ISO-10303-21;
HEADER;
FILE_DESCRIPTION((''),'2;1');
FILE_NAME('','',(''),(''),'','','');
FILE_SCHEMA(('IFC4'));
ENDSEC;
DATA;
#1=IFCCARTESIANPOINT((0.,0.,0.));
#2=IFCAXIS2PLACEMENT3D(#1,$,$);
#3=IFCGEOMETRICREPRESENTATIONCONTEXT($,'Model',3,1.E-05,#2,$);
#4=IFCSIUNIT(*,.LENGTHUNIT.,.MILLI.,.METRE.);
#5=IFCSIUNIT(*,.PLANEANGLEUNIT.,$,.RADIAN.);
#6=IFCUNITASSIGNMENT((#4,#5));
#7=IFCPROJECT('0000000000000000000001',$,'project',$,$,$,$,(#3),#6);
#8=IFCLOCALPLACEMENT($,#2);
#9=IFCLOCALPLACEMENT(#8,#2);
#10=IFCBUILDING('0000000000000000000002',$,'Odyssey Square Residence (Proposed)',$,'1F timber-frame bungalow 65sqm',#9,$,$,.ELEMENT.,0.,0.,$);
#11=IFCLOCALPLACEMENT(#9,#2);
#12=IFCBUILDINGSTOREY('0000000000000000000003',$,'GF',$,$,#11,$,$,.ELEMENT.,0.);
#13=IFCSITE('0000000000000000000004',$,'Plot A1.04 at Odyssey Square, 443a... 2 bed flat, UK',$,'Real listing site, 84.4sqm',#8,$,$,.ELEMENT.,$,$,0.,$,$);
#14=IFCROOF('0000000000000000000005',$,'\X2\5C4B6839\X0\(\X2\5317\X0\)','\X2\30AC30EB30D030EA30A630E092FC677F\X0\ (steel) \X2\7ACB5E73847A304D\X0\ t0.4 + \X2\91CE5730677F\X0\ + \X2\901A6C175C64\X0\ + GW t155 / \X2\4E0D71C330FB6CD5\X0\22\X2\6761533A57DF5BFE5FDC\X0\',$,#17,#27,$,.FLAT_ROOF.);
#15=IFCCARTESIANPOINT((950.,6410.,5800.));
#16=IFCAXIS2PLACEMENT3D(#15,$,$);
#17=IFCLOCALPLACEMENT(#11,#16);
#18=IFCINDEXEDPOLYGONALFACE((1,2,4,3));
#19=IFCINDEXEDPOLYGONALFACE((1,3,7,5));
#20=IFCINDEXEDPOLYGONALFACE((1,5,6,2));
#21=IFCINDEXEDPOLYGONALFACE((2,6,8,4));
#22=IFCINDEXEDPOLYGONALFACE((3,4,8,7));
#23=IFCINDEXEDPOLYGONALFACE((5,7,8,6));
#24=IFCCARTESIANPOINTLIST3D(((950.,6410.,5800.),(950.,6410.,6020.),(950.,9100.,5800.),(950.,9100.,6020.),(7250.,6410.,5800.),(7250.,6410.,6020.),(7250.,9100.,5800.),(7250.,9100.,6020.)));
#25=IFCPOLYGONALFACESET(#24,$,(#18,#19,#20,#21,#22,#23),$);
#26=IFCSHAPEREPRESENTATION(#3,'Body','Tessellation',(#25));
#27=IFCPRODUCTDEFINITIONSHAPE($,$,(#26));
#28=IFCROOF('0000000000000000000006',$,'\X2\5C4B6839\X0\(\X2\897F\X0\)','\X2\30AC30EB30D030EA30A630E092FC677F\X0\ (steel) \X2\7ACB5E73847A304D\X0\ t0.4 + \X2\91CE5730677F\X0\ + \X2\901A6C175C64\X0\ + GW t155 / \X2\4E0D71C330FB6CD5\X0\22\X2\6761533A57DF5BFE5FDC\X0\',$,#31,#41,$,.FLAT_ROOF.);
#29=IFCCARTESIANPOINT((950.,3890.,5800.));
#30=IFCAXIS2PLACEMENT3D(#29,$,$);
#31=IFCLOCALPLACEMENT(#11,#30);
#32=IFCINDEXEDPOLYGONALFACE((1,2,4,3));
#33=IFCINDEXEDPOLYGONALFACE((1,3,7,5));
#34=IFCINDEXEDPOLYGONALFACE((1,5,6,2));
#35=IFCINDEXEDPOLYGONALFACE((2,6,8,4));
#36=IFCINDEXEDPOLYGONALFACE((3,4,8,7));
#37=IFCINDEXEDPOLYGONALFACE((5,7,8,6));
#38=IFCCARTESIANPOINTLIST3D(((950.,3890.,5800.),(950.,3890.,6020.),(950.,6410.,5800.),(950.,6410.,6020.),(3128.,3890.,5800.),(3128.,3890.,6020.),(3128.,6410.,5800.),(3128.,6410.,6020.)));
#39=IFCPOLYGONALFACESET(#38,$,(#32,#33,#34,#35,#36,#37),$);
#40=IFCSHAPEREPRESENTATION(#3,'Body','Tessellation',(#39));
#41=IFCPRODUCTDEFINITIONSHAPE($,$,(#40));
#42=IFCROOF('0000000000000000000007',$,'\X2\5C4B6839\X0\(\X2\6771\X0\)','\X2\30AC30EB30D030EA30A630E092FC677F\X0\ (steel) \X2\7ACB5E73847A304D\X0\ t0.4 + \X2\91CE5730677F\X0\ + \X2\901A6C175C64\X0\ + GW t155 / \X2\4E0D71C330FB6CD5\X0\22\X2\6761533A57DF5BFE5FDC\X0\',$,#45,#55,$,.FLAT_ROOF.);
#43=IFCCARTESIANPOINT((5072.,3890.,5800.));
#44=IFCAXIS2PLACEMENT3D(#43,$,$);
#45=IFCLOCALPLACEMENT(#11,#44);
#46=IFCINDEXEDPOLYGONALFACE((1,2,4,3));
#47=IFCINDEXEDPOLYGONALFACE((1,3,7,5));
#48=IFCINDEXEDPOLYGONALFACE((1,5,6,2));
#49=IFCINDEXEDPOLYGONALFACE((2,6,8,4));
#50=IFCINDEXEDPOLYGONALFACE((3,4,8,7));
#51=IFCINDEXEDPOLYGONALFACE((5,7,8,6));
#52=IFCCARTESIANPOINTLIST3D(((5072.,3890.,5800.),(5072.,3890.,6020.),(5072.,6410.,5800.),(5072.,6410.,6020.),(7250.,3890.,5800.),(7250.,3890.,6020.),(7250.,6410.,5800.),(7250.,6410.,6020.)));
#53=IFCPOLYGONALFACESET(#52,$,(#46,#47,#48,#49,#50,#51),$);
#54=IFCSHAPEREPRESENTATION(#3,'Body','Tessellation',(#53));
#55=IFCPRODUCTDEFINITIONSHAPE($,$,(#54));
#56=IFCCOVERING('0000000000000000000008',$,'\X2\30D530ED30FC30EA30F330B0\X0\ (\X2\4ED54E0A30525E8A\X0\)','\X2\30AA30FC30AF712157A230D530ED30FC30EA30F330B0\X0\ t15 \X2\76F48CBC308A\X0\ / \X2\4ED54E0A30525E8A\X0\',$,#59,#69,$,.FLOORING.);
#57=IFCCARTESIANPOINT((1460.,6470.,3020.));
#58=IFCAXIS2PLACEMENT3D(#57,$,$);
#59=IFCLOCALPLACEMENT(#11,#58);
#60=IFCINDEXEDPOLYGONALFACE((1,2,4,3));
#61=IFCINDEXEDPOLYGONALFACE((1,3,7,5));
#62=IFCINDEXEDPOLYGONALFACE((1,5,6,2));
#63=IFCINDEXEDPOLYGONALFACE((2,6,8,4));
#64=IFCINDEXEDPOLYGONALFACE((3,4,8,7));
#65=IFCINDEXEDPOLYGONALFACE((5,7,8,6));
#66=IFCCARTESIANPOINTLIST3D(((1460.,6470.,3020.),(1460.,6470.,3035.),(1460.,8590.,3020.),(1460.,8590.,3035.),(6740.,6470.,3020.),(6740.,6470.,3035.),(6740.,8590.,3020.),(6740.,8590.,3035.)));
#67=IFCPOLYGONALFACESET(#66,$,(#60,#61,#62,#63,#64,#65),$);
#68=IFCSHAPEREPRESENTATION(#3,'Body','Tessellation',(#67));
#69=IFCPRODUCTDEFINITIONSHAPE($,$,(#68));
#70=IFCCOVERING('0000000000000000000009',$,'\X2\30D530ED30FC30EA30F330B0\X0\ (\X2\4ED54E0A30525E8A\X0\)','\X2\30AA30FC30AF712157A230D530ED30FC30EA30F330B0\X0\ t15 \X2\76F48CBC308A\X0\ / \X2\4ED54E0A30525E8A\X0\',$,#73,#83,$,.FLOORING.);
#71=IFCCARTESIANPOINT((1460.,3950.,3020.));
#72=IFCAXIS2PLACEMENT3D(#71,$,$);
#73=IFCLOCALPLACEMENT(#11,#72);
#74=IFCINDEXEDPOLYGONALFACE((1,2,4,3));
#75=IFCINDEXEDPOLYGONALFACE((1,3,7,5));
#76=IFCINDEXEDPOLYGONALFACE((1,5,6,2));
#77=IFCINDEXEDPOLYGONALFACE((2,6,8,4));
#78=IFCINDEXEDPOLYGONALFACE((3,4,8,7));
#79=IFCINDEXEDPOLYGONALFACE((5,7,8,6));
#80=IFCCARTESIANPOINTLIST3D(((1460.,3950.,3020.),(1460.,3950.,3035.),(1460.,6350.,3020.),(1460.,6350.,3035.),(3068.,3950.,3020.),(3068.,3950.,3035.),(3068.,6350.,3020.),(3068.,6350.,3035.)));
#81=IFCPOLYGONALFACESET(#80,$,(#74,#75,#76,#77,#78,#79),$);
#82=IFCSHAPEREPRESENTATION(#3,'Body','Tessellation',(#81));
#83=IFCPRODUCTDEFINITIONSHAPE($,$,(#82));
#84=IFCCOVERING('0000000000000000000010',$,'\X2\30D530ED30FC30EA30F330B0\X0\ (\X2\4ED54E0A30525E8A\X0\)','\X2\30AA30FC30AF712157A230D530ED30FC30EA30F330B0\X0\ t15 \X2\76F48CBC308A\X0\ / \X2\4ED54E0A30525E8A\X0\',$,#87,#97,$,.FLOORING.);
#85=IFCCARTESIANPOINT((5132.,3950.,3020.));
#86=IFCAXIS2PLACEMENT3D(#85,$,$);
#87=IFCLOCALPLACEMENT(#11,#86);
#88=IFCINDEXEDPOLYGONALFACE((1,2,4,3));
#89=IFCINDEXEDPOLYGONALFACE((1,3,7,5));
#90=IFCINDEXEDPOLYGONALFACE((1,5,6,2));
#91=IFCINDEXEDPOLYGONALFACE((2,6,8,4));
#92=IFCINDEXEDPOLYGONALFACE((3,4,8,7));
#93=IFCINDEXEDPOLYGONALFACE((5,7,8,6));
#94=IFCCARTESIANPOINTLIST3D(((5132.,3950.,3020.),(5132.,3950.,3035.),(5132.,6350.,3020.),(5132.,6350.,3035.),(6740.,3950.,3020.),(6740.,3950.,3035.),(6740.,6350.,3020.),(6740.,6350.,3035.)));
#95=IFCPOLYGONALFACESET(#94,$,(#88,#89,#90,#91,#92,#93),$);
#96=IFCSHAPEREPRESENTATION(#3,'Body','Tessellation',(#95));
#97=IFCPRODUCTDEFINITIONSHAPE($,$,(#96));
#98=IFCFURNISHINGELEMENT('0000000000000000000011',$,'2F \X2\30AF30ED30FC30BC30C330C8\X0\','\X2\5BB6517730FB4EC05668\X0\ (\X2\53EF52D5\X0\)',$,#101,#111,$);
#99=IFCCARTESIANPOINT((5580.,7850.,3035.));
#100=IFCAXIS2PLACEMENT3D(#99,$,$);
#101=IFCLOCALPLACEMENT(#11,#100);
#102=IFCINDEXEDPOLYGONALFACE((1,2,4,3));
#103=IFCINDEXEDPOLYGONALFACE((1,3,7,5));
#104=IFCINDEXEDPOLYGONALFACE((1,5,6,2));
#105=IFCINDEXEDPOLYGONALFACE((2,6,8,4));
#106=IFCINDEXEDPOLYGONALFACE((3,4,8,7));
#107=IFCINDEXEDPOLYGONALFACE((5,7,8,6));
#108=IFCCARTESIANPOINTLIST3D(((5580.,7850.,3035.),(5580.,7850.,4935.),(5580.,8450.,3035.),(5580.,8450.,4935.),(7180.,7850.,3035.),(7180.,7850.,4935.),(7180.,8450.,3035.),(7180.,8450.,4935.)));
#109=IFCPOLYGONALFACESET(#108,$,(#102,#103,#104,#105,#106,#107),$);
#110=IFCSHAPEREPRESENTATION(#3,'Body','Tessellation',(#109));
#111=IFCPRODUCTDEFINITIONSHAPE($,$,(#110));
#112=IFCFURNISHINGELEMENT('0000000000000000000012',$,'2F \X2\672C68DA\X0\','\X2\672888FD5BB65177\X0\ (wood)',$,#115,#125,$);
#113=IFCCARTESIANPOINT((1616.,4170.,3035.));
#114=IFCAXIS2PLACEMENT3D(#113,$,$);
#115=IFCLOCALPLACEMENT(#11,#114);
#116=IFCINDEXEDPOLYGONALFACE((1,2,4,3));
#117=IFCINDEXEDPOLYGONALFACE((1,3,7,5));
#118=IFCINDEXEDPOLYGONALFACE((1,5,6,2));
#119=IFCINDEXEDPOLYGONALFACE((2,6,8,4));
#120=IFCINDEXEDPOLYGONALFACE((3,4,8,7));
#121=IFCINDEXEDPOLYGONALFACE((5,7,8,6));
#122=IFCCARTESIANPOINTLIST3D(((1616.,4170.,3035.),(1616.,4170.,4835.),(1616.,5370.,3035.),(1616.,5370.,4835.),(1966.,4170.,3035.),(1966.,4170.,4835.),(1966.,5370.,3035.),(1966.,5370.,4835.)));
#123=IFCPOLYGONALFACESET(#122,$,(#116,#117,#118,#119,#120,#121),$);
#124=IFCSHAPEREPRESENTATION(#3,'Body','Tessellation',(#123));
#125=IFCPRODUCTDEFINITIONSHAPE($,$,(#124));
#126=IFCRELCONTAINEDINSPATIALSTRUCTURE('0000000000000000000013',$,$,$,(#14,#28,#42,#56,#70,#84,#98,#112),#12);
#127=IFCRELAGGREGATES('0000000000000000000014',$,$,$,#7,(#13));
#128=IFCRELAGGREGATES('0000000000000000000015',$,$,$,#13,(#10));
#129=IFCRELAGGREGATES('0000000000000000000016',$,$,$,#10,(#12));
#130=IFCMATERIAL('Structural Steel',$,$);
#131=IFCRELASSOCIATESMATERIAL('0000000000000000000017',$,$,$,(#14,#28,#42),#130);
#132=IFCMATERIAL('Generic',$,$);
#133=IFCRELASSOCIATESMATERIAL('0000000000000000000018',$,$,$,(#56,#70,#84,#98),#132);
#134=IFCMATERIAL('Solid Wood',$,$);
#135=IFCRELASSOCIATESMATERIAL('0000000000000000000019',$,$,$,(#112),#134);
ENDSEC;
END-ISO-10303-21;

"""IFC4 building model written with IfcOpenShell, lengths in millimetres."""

from ifc_helpers import new_model, si_unit, frame, frame_2d, origin, place, context, project, spatial, rectangle, extrude, material, element, save


model = new_model("IFC4")

# Units and contexts
model_context = context("Model", 3, precision=1e-05, world=origin())
ifc_project = project(units=[si_unit("LENGTHUNIT", "METRE", prefix="MILLI"), si_unit("PLANEANGLEUNIT", "RADIAN")], contexts=[model_context])

# Site, building, storey
site_placement = place(None, origin())
site = spatial("IfcSite", under=ifc_project, at=site_placement, Name="Plot A1.04 at Odyssey Square, 443a... 2 bed flat, UK", ObjectType="Real listing site, 84.4sqm", CompositionType="ELEMENT", RefElevation=0.0)
building_placement = place(site_placement, origin())
building = spatial("IfcBuilding", under=site, at=building_placement, Name="Odyssey Square Residence (Proposed)", ObjectType="1F timber-frame bungalow 65sqm", CompositionType="ELEMENT", ElevationOfRefHeight=0.0, ElevationOfTerrain=0.0)
storey_placement = place(building_placement, origin())
storey = spatial("IfcBuildingStorey", under=building, at=storey_placement, Name="GF", CompositionType="ELEMENT", Elevation=0.0)

# Shared definitions
ifc_material_1 = material(Name="Solid Wood")

# Shared definitions
ifc_material_2 = material(Name="Generic")

# Roofs
ifc_material_3 = material(Name="Structural Steel")
for number, where, name in (
    (1, (950.0, 6410.0, 5800.0), "屋根(北)"),
):
    element("IfcRoof", number, at=place(storey_placement, frame(where)), inside=storey, material=ifc_material_3, Name=name, Description="ガルバリウム鋼板 (steel) 立平葺き t0.4 + 野地板 + 通気層 + GW t155 / 不燃・法22条区域対応", PredefinedType="FLAT_ROOF", context=model_context, shape_type="SweptSolid", body=[
        extrude(rectangle(XDim=6300.0, YDim=2690.0, at=frame_2d((3150.0, 1345.0))), frame((950.0, 6410.0, 5800.0)), (0.0, 0.0, 1.0), 220.0),
    ])
roof_1_placement = place(storey_placement, frame((950.0, 3890.0, 5800.0)))
element("IfcRoof", 2, at=roof_1_placement, inside=storey, material=ifc_material_3, Name="屋根(西)", Description="ガルバリウム鋼板 (steel) 立平葺き t0.4 + 野地板 + 通気層 + GW t155 / 不燃・法22条区域対応", PredefinedType="FLAT_ROOF", context=model_context, shape_type="SweptSolid", body=[
    extrude(rectangle(XDim=2178.0, YDim=2520.0, at=frame_2d((1089.0, 1260.0))), frame((950.0, 3890.0, 5800.0)), (0.0, 0.0, 1.0), 220.0),
])
roof_2_placement = place(storey_placement, frame((5072.0, 3890.0, 5800.0)))
element("IfcRoof", 3, at=roof_2_placement, inside=storey, material=ifc_material_3, Name="屋根(東)", Description="ガルバリウム鋼板 (steel) 立平葺き t0.4 + 野地板 + 通気層 + GW t155 / 不燃・法22条区域対応", PredefinedType="FLAT_ROOF", context=model_context, shape_type="SweptSolid", body=[
    extrude(rectangle(XDim=2178.0, YDim=2520.0, at=frame_2d((1089.0, 1260.0))), frame((5072.0, 3890.0, 5800.0)), (0.0, 0.0, 1.0), 220.0),
])

# Coverings
covering_1_placement = place(storey_placement, frame((1460.0, 6470.0, 3020.0)))
element("IfcCovering", 4, at=covering_1_placement, inside=storey, material=ifc_material_2, Name="フローリング (仕上げ床)", Description="オーク無垢フローリング t15 直貼り / 仕上げ床", PredefinedType="FLOORING", context=model_context, shape_type="SweptSolid", body=[
    extrude(rectangle(XDim=5280.0, YDim=2120.0, at=frame_2d((2640.0, 1060.0))), frame((1460.0, 6470.0, 3020.0)), (0.0, 0.0, 1.0), 15.0),
])
covering_2_placement = place(storey_placement, frame((1460.0, 3950.0, 3020.0)))
element("IfcCovering", 5, at=covering_2_placement, inside=storey, material=ifc_material_2, Name="フローリング (仕上げ床)", Description="オーク無垢フローリング t15 直貼り / 仕上げ床", PredefinedType="FLOORING", context=model_context, shape_type="SweptSolid", body=[
    extrude(rectangle(XDim=1608.0, YDim=2400.0, at=frame_2d((804.0, 1200.0))), frame((1460.0, 3950.0, 3020.0)), (0.0, 0.0, 1.0), 15.0),
])
covering_3_placement = place(storey_placement, frame((5132.0, 3950.0, 3020.0)))
element("IfcCovering", 6, at=covering_3_placement, inside=storey, material=ifc_material_2, Name="フローリング (仕上げ床)", Description="オーク無垢フローリング t15 直貼り / 仕上げ床", PredefinedType="FLOORING", context=model_context, shape_type="SweptSolid", body=[
    extrude(rectangle(XDim=1608.0, YDim=2400.0, at=frame_2d((804.0, 1200.0))), frame((5132.0, 3950.0, 3020.0)), (0.0, 0.0, 1.0), 15.0),
])

# Furnishing elements
furnishing_1_placement = place(storey_placement, frame((5580.0, 7850.0, 3035.0)))
element("IfcFurnishingElement", 7, at=furnishing_1_placement, inside=storey, material=ifc_material_2, Name="2F クローゼット", Description="家具・什器 (可動)", context=model_context, shape_type="SweptSolid", body=[
    extrude(rectangle(XDim=1600.0, YDim=600.0, at=frame_2d((800.0, 300.0))), frame((5580.0, 7850.0, 3035.0)), (0.0, 0.0, 1.0), 1900.0),
])
furnishing_2_placement = place(storey_placement, frame((1616.0, 4170.0, 3035.0)))
element("IfcFurnishingElement", 8, at=furnishing_2_placement, inside=storey, material=ifc_material_1, Name="2F 本棚", Description="木製家具 (wood)", context=model_context, shape_type="SweptSolid", body=[
    extrude(rectangle(XDim=350.0, YDim=1200.0, at=frame_2d((175.0, 600.0))), frame((1616.0, 4170.0, 3035.0)), (0.0, 0.0, 1.0), 1800.0),
])

save(model, "model.ifc")
